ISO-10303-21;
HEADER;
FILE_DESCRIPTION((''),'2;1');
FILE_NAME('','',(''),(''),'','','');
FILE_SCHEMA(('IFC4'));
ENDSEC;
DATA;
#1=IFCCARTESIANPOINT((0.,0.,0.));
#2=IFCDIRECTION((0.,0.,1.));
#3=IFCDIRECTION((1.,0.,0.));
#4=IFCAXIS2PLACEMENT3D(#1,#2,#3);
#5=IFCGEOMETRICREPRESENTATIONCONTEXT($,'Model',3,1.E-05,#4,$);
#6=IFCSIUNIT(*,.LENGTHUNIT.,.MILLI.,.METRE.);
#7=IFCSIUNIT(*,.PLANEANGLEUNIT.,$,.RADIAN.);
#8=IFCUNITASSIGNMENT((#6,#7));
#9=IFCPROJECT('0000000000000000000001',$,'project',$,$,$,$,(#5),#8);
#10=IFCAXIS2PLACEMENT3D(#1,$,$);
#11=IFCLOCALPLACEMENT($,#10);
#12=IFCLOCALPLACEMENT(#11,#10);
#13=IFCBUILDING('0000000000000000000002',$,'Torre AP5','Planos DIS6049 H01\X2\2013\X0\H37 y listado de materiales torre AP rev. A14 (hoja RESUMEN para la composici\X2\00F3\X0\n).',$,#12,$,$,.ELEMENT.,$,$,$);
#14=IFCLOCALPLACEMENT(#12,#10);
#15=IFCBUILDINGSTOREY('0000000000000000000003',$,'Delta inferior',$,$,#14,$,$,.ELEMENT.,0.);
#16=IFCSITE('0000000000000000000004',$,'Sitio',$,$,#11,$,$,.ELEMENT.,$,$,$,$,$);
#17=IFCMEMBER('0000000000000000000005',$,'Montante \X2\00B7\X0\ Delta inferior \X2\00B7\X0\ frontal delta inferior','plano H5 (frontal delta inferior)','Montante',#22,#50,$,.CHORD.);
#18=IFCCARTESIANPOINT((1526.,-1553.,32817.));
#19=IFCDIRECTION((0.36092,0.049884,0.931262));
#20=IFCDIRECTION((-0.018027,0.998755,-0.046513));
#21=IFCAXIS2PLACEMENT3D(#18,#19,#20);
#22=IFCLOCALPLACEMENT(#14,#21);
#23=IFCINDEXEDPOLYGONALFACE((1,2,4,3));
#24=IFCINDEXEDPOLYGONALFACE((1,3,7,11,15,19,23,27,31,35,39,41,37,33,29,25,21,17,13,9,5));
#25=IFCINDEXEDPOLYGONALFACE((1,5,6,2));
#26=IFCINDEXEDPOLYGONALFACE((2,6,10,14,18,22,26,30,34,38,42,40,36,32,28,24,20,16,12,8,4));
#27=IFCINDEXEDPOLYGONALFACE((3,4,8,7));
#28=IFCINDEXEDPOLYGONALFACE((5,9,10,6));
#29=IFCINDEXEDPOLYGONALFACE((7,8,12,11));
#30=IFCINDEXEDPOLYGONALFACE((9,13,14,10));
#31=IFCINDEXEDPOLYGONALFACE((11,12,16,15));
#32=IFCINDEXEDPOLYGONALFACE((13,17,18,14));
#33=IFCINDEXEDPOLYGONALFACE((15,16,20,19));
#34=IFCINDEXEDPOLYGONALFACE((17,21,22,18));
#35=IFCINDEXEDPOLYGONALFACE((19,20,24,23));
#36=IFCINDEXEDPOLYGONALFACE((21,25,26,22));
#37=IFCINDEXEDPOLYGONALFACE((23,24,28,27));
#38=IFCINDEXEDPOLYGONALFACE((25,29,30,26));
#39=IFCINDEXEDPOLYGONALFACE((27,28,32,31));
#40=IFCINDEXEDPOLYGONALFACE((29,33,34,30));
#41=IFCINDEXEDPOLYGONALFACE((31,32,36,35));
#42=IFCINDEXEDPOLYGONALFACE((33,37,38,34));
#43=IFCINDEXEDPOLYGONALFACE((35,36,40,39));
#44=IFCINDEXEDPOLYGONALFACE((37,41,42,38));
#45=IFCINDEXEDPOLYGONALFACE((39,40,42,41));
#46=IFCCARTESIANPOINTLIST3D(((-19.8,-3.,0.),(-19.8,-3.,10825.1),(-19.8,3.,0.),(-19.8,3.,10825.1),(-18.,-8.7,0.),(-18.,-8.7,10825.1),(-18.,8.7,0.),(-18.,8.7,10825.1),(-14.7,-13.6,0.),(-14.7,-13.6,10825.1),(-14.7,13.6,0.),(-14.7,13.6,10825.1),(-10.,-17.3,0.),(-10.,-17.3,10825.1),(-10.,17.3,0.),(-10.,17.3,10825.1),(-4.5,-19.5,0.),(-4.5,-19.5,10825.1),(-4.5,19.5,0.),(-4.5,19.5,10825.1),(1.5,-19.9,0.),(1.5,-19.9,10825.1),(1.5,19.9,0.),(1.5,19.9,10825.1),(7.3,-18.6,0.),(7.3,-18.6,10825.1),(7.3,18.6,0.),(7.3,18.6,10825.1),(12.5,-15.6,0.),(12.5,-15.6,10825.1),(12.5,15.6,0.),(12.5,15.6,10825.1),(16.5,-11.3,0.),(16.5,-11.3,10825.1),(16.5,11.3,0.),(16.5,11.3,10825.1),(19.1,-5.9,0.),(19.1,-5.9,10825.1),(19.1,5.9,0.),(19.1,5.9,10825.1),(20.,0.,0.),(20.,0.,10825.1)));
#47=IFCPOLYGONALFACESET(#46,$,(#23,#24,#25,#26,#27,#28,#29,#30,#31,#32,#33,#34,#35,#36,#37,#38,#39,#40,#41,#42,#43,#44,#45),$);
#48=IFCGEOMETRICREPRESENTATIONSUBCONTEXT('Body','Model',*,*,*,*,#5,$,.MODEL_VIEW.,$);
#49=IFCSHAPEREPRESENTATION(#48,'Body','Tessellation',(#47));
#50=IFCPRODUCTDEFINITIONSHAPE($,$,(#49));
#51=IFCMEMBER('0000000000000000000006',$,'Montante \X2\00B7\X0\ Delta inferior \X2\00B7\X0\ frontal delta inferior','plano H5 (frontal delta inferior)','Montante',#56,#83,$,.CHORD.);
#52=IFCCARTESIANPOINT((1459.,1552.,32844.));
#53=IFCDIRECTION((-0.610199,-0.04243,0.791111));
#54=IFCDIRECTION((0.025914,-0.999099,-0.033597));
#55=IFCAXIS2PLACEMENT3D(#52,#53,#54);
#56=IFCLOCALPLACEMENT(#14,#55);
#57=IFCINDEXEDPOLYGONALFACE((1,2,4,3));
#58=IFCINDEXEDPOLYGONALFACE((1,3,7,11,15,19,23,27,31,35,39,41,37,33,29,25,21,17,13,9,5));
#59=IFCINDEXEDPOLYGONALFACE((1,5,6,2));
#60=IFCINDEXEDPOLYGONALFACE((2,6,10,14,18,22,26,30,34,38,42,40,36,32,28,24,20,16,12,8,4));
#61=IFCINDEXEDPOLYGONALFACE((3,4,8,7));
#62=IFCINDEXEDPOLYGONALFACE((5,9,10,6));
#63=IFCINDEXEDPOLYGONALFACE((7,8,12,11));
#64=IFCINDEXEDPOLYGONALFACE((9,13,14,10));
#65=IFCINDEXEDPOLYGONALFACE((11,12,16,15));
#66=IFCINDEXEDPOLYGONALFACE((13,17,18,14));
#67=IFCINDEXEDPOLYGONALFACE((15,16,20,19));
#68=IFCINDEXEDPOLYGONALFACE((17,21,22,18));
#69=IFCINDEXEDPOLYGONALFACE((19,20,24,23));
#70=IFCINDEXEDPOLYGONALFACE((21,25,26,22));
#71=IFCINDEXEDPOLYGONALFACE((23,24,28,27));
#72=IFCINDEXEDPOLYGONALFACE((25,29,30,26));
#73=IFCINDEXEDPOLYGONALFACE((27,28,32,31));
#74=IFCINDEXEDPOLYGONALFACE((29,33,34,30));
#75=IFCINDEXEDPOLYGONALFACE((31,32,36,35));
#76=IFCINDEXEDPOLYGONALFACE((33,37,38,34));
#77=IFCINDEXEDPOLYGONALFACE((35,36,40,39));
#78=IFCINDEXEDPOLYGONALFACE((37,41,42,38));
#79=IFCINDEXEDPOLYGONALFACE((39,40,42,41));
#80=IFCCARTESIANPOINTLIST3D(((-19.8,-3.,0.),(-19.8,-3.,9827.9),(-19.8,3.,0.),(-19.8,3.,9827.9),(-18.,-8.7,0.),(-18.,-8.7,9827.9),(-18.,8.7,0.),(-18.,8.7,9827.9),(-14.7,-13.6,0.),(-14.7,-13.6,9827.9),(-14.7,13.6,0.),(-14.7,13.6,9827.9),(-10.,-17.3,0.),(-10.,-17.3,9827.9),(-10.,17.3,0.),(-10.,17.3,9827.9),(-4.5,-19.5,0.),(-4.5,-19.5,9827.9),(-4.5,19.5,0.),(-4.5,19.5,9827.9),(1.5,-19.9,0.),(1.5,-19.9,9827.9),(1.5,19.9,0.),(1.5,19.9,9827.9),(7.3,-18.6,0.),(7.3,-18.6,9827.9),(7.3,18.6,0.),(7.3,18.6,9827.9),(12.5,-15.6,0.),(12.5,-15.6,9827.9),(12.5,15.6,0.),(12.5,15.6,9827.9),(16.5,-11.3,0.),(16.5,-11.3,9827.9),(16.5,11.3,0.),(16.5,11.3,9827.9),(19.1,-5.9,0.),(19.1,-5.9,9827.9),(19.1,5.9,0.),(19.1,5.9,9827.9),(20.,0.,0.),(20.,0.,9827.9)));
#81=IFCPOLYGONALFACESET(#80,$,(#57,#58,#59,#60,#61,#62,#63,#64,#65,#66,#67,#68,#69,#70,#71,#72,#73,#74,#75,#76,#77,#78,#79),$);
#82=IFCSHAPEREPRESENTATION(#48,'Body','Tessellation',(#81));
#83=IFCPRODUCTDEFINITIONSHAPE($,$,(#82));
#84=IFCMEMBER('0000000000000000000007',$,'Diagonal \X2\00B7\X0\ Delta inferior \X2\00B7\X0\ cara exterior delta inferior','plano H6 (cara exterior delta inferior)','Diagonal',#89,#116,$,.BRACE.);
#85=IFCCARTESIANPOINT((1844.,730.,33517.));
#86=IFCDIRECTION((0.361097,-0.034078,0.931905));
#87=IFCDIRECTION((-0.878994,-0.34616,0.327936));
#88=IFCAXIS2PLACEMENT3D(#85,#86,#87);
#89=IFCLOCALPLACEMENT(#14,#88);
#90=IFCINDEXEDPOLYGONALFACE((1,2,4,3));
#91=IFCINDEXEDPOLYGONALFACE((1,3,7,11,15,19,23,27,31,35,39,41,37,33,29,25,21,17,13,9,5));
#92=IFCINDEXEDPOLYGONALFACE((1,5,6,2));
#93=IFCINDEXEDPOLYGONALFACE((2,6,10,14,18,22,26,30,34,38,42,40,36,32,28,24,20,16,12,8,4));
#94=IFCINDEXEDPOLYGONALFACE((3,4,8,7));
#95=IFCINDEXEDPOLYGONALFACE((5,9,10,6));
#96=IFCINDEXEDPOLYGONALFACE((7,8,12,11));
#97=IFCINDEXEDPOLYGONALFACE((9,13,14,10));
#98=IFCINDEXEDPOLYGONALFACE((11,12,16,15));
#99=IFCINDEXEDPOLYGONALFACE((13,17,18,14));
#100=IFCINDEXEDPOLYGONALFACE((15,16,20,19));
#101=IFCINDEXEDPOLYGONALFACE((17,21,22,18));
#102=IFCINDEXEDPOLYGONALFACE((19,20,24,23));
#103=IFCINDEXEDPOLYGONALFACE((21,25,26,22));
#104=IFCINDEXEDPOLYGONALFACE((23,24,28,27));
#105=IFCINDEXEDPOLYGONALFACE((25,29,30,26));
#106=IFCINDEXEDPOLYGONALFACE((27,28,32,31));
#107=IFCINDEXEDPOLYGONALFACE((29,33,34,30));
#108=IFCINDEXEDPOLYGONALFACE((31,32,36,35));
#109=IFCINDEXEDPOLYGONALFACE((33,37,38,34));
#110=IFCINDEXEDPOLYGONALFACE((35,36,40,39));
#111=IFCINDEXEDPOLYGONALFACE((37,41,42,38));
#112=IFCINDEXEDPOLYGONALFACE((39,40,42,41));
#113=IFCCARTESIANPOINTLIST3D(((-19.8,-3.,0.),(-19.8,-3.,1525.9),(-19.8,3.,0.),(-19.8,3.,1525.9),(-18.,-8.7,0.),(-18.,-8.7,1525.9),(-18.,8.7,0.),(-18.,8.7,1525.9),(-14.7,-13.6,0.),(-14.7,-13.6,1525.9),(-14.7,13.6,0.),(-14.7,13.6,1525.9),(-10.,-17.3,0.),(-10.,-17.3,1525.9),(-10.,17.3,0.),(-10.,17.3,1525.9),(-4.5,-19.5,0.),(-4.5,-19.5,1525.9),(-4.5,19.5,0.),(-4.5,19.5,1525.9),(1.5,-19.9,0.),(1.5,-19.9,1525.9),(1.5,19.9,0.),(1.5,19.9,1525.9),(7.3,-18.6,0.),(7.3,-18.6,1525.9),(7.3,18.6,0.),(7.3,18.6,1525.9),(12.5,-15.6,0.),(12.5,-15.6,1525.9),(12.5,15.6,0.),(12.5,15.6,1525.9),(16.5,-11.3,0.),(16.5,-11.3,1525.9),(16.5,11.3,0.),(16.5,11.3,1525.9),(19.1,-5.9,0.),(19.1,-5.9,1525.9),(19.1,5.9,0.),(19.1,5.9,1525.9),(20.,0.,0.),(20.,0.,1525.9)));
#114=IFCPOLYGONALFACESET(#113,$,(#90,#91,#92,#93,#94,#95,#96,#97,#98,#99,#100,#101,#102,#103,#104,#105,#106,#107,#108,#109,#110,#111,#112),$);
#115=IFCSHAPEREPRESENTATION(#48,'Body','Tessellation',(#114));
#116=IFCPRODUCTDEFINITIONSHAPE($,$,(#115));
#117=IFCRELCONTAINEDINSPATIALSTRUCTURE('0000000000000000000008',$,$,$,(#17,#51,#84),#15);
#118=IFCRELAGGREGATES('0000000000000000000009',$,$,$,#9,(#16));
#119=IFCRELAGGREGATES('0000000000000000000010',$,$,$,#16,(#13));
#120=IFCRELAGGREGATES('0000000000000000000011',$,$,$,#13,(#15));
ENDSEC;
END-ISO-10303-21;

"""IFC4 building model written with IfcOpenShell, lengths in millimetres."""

from ifc_helpers import new_model, si_unit, frame, origin, origin_with_axes, place, context, subcontext, project, spatial, circle, extrude, element, save


model = new_model("IFC4")

# Units and contexts
model_context = context("Model", 3, precision=1e-05, world=origin_with_axes())
body_context = subcontext(model_context, "Body", "Model", "MODEL_VIEW")
ifc_project = project(units=[si_unit("LENGTHUNIT", "METRE", prefix="MILLI"), si_unit("PLANEANGLEUNIT", "RADIAN")], contexts=[model_context])

# Site, building, storey
site_placement = place(None, origin())
site = spatial("IfcSite", under=ifc_project, at=site_placement, Name="Sitio", CompositionType="ELEMENT")
building_placement = place(site_placement, origin())
building = spatial("IfcBuilding", under=site, at=building_placement, Name="Torre AP5", Description="Planos DIS6049 H01–H37 y listado de materiales torre AP rev. A14 (hoja RESUMEN para la composición).", CompositionType="ELEMENT")
storey_placement = place(building_placement, origin())
storey = spatial("IfcBuildingStorey", under=building, at=storey_placement, Name="Delta inferior", CompositionType="ELEMENT", Elevation=0.0)

# Members
for number, where, z_axis, x_axis, name in (
    (1, (1526.0, -1553.0, 32817.0), (0.36092, 0.049884, 0.931262), (-0.018027, 0.998755, -0.046513), "Montante · Delta inferior · frontal delta inferior"),
):
    element("IfcMember", number, at=place(storey_placement, frame(where, z_axis=z_axis, x_axis=x_axis)), inside=storey, Name=name, Description="plano H5 (frontal delta inferior)", ObjectType="Montante", PredefinedType="CHORD", context=body_context, shape_type="SweptSolid", body=[
        extrude(circle(Radius=20.0), None, (0.0, 0.0, 1.0), 10825.1),
    ])
for number, where, z_axis, x_axis, name in (
    (2, (1459.0, 1552.0, 32844.0), (-0.610199, -0.04243, 0.791111), (0.025914, -0.999099, -0.033597), "Montante · Delta inferior · frontal delta inferior"),
):
    element("IfcMember", number, at=place(storey_placement, frame(where, z_axis=z_axis, x_axis=x_axis)), inside=storey, Name=name, Description="plano H5 (frontal delta inferior)", ObjectType="Montante", PredefinedType="CHORD", context=body_context, shape_type="SweptSolid", body=[
        extrude(circle(Radius=20.0), None, (0.0, 0.0, 1.0), 9827.9),
    ])
member_1_placement = place(storey_placement, frame((1844.0, 730.0, 33517.0), z_axis=(0.361097, -0.034078, 0.931905), x_axis=(-0.878994, -0.34616, 0.327936)))
element("IfcMember", 3, at=member_1_placement, inside=storey, Name="Diagonal · Delta inferior · cara exterior delta inferior", Description="plano H6 (cara exterior delta inferior)", ObjectType="Diagonal", PredefinedType="BRACE", context=body_context, shape_type="SweptSolid", body=[
    extrude(circle(Radius=20.0), None, (0.0, 0.0, 1.0), 1525.9),
])

save(model, "model.ifc")
